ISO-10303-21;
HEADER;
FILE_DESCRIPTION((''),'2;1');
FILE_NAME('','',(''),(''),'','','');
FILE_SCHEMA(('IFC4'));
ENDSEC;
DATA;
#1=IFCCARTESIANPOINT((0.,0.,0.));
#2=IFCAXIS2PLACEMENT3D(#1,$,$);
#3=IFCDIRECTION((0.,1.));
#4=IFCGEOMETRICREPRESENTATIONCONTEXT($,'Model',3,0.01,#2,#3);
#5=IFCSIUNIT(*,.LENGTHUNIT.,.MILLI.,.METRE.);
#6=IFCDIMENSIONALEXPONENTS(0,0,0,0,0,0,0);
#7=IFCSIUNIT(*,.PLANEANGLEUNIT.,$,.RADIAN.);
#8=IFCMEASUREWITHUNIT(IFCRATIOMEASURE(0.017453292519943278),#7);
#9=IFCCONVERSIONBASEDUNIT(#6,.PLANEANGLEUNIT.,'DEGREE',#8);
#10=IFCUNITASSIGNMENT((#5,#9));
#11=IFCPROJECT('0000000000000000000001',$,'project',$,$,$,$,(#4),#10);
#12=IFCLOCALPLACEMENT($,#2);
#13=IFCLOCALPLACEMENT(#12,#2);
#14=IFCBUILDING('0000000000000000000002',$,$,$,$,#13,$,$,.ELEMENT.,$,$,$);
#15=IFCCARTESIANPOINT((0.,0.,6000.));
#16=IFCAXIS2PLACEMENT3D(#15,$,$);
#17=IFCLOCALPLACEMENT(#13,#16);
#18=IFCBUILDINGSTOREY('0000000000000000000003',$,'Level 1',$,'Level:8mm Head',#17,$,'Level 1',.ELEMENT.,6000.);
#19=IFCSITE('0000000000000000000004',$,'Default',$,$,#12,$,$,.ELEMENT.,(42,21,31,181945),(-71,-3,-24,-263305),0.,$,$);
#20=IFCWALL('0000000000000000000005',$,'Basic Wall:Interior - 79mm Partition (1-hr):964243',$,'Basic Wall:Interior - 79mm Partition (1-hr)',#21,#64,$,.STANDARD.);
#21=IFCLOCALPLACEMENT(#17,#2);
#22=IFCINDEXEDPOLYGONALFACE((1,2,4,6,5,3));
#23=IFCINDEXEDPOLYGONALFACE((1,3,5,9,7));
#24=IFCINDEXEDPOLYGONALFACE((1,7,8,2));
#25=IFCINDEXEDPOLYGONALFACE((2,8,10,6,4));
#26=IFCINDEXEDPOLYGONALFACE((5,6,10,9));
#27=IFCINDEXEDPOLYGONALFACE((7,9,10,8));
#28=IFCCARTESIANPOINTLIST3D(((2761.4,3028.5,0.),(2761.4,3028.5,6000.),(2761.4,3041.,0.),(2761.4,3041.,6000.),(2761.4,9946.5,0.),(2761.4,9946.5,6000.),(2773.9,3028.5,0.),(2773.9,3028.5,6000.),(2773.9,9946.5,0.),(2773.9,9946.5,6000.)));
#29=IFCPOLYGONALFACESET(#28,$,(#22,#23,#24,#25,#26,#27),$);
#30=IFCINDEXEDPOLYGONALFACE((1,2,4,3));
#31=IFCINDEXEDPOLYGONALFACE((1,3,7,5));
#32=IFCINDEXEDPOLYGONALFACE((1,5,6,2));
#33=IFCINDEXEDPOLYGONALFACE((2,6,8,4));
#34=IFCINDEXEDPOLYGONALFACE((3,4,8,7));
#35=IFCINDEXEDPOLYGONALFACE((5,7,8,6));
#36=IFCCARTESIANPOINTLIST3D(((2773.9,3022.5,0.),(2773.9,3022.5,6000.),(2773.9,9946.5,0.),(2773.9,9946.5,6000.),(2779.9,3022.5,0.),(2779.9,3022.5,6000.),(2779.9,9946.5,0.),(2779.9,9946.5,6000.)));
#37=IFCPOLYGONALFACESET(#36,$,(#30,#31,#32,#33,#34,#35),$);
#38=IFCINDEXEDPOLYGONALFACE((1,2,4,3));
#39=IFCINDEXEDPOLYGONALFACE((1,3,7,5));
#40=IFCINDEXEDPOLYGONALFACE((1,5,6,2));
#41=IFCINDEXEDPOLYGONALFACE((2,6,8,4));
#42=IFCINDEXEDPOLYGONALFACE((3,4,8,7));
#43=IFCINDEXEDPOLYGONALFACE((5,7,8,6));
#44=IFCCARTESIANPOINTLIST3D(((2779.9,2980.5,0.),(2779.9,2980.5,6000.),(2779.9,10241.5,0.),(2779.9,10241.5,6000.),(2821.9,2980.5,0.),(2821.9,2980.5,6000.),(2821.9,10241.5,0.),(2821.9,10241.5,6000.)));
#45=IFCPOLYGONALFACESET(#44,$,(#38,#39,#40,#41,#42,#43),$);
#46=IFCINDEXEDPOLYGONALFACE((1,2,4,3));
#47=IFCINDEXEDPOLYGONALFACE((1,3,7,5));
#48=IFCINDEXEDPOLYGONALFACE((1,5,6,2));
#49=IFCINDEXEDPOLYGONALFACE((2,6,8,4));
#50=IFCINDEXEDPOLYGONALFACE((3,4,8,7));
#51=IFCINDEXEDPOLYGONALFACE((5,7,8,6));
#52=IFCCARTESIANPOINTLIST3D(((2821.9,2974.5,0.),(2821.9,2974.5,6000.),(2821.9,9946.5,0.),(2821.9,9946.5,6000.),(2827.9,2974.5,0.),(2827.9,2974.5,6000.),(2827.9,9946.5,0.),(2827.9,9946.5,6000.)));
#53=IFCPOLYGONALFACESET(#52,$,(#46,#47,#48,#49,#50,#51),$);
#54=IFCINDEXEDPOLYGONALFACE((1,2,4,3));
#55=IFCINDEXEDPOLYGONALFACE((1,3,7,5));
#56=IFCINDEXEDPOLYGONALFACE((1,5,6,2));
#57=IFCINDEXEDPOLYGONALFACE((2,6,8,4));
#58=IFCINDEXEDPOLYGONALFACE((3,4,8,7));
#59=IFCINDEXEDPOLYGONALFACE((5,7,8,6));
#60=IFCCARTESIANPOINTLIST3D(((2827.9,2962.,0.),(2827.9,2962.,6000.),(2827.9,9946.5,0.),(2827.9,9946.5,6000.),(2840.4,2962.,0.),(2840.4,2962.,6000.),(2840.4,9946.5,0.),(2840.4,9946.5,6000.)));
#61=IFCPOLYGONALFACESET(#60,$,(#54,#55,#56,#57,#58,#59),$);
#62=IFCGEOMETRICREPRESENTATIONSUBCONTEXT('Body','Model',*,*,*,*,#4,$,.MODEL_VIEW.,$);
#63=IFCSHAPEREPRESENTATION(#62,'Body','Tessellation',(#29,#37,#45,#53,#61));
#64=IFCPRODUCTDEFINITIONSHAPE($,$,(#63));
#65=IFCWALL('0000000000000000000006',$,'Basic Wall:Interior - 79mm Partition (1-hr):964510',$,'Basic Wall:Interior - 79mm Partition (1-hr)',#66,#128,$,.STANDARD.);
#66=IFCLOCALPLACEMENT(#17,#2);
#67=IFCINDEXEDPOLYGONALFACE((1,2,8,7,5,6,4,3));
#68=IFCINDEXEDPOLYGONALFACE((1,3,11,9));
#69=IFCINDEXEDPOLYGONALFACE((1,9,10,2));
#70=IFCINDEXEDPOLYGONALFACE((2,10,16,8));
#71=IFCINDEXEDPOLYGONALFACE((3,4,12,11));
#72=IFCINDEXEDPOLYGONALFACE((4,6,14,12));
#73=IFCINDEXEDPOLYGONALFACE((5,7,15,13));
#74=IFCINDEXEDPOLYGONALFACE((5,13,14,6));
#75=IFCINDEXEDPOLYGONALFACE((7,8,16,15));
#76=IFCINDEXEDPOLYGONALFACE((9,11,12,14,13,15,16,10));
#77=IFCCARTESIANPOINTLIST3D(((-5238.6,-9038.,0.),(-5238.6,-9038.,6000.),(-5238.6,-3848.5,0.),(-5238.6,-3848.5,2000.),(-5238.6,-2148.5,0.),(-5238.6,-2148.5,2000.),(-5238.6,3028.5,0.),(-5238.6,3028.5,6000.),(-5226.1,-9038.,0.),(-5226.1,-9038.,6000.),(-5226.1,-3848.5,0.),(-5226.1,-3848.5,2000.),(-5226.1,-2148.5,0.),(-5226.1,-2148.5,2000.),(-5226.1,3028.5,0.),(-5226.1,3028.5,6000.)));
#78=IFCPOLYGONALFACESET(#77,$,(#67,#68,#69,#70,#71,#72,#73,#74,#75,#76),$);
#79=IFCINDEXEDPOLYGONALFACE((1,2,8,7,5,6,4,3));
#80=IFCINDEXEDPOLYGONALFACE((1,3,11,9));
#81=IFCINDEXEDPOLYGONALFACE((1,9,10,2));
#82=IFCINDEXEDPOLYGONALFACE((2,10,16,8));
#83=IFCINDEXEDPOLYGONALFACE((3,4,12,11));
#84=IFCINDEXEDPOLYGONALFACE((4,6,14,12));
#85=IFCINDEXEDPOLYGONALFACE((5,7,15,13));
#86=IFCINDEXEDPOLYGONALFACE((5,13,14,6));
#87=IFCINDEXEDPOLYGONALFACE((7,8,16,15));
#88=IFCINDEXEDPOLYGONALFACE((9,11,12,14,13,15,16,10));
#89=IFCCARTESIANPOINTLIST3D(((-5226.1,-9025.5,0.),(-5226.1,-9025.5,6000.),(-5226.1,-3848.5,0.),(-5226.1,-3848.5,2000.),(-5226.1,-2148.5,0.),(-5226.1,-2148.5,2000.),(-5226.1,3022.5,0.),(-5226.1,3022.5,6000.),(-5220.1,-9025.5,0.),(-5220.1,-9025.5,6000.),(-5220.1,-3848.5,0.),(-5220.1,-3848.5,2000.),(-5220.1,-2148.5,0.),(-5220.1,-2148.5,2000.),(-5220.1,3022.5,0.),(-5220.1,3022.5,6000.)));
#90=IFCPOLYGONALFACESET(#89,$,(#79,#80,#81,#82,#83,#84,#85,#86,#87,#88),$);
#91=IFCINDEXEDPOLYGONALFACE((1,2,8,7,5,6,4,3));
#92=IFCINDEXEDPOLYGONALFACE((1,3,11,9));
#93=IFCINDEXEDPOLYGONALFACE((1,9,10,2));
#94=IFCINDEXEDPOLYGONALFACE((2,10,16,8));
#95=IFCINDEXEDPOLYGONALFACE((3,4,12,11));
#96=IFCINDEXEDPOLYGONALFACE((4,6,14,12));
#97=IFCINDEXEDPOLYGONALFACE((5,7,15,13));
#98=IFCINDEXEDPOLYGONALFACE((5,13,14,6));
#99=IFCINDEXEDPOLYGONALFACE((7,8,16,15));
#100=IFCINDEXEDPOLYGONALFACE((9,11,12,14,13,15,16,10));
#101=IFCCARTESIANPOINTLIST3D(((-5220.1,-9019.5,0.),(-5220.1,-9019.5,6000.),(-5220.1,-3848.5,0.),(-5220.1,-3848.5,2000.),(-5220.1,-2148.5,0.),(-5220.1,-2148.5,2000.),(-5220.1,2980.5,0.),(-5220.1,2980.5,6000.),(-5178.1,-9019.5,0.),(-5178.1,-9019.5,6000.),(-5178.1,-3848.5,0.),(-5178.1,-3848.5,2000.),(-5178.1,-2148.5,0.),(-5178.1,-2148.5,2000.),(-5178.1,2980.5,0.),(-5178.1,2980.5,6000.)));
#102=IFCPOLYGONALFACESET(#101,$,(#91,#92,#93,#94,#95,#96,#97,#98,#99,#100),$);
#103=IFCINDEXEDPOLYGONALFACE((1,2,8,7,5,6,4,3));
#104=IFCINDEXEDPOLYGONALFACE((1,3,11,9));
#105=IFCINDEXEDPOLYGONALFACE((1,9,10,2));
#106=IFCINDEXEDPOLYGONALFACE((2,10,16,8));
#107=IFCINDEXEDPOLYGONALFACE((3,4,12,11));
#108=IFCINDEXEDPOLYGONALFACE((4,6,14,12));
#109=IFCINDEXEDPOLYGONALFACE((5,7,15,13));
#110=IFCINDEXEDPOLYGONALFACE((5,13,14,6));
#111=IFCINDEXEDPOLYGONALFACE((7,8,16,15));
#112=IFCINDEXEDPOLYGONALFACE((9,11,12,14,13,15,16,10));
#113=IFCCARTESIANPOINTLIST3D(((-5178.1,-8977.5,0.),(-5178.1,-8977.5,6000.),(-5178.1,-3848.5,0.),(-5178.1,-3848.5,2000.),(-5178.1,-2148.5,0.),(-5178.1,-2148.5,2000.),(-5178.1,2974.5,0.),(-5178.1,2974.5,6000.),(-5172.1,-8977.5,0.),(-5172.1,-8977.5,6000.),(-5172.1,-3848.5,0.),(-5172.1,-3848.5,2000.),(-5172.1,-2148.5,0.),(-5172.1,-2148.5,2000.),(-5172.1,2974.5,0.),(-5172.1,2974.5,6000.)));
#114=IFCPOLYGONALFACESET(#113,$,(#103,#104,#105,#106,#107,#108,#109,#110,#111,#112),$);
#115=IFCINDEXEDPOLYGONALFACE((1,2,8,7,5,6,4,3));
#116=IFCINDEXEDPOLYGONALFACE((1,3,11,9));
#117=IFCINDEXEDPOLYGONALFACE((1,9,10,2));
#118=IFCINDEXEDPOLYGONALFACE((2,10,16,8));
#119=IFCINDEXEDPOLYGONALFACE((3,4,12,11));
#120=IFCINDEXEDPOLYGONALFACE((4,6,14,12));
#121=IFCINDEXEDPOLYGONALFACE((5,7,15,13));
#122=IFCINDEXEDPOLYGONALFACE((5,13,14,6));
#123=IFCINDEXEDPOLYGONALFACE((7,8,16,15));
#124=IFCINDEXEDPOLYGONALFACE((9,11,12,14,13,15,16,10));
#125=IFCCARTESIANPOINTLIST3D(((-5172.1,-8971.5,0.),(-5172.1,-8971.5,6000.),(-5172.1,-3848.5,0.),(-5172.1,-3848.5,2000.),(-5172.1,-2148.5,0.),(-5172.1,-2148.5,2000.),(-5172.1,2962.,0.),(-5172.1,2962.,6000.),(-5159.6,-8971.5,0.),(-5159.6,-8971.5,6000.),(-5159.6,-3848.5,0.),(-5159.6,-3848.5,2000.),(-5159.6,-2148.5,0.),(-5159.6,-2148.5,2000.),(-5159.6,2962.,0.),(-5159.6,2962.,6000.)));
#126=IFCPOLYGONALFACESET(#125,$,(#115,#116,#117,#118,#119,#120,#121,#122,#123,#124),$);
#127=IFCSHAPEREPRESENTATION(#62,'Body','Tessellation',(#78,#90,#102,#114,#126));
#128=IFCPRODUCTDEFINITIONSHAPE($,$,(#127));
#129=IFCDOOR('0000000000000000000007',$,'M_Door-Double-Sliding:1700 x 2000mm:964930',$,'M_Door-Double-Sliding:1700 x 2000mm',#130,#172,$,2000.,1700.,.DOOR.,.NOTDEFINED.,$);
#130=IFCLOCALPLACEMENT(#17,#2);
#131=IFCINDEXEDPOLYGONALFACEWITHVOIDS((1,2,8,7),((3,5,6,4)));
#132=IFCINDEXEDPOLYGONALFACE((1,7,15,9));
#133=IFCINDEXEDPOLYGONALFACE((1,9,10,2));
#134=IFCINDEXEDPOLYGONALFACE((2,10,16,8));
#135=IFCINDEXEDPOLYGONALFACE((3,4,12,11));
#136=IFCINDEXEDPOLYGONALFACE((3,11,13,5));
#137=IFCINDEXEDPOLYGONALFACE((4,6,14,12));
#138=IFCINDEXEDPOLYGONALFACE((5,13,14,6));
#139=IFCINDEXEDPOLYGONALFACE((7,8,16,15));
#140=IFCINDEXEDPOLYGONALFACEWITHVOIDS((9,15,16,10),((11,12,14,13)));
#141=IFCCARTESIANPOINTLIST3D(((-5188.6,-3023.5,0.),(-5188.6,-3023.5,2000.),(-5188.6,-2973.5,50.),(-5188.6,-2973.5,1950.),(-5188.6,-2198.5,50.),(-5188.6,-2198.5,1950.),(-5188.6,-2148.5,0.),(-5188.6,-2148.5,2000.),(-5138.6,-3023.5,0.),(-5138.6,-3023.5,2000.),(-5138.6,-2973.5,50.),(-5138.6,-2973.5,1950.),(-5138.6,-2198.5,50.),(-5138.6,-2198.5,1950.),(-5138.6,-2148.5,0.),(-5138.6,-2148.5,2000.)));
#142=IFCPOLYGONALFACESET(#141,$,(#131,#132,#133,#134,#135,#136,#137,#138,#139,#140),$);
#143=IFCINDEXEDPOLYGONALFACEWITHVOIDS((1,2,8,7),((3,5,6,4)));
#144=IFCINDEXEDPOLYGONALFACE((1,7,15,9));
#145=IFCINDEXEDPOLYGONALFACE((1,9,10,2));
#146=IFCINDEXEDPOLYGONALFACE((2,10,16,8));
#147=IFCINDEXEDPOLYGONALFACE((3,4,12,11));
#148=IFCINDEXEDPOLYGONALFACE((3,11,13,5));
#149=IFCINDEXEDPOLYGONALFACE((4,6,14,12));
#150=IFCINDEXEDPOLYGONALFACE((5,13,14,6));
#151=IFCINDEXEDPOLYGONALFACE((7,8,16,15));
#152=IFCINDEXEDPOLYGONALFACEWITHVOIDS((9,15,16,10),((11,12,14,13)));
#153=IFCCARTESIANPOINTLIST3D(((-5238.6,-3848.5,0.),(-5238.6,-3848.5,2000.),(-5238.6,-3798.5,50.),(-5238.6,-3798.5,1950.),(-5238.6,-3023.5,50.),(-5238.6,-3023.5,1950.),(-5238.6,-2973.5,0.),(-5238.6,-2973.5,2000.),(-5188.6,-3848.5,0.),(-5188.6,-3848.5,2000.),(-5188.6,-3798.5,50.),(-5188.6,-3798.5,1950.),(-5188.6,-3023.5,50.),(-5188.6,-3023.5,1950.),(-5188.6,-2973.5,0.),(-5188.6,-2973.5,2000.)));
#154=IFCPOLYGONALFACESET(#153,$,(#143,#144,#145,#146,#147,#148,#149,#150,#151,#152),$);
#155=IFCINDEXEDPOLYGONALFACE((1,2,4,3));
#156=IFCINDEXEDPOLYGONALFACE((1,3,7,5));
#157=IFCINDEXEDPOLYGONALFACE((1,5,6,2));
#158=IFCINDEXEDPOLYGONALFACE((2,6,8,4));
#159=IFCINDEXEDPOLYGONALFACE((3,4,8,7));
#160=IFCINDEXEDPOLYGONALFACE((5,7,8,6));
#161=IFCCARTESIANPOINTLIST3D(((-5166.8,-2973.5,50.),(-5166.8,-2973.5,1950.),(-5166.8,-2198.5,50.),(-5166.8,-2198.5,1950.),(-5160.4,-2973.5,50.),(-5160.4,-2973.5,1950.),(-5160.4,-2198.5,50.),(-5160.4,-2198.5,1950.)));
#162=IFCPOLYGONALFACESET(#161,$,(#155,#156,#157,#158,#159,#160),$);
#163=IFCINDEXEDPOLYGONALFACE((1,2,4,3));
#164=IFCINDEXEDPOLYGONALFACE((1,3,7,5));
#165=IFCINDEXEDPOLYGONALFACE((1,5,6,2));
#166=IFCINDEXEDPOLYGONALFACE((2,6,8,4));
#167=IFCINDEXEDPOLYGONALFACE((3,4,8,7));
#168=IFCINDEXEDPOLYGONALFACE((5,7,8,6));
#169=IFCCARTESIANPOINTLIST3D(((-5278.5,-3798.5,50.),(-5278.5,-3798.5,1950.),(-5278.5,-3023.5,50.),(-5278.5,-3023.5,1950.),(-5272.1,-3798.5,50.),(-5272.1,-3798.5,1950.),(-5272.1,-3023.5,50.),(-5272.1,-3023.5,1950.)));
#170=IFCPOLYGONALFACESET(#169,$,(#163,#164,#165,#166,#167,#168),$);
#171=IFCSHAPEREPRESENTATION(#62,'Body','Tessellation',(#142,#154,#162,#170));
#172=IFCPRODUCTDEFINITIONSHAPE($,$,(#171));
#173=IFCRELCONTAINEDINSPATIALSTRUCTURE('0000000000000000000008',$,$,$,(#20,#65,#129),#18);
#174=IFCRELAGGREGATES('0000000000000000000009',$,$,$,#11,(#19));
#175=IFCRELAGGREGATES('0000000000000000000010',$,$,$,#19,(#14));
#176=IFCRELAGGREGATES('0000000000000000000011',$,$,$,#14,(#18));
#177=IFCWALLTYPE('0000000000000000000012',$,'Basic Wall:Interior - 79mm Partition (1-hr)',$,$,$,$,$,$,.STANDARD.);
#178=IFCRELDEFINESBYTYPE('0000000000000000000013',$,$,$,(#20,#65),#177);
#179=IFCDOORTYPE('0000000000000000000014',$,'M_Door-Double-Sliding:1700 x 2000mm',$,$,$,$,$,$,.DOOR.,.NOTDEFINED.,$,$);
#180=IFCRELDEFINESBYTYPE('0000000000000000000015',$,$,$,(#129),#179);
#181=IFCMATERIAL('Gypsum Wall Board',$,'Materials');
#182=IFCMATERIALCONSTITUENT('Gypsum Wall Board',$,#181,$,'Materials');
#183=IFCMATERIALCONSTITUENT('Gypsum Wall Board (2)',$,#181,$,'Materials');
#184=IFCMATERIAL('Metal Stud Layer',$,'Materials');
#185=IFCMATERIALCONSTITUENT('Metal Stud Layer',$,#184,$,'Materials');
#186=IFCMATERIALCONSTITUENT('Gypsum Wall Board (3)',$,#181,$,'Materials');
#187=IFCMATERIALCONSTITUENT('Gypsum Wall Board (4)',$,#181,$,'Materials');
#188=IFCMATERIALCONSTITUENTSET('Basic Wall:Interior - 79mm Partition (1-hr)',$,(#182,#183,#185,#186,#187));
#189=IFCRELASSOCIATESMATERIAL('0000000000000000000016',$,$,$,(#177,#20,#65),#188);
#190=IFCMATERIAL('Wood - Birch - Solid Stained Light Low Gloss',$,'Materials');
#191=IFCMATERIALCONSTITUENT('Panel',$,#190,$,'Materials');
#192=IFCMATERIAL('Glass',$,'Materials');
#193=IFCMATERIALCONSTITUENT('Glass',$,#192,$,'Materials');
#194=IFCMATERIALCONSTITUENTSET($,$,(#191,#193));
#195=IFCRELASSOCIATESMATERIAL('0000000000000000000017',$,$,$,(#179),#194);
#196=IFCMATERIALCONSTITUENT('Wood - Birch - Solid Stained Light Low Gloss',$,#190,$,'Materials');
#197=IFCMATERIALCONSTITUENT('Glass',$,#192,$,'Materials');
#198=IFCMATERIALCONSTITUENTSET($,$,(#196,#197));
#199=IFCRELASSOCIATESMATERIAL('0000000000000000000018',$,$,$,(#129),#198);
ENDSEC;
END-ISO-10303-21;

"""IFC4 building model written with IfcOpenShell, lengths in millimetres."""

from ifc_helpers import new_model, entity, si_unit, converted_unit, direction, frame, origin, place, context, subcontext, project, spatial, indexed_curve, outline, extrude, source, transform, mapped, material, constituent, constituent_set, type_object, type_shapes, element, fill, save


model = new_model("IFC4")

# Units and contexts
model_context = context("Model", 3, precision=0.01, world=origin(), true_north=direction((0.0, 1.0)))
body_context = subcontext(model_context, "Body", "Model", "MODEL_VIEW")
ifc_project = project(units=[si_unit("LENGTHUNIT", "METRE", prefix="MILLI"), converted_unit("PLANEANGLEUNIT", "DEGREE", entity("IfcRatioMeasure", 0.017453292519943278), si_unit("PLANEANGLEUNIT", "RADIAN"), dimensions=[0, 0, 0, 0, 0, 0, 0])], contexts=[model_context])

# Site, building, storey
site_placement = place(None, origin())
site = spatial("IfcSite", under=ifc_project, at=site_placement, Name="Default", CompositionType="ELEMENT", RefLatitude=(42, 21, 31, 181945), RefLongitude=(-71, -3, -24, -263305), RefElevation=0.0)
building_placement = place(site_placement, origin())
building = spatial("IfcBuilding", under=site, at=building_placement, CompositionType="ELEMENT")
storey_placement = place(building_placement, frame((0.0, 0.0, 6000.0)))
storey = spatial("IfcBuildingStorey", under=building, at=storey_placement, Name="Level 1", ObjectType="Level:8mm Head", LongName="Level 1", CompositionType="ELEMENT", Elevation=6000.0)

# Wall
ifc_material_1 = material(Name="Gypsum Wall Board", Category="Materials")
ifc_constituent_1 = constituent(ifc_material_1, Name="Gypsum Wall Board", Category="Materials")
ifc_constituent_2 = constituent(ifc_material_1, Name="Gypsum Wall Board (2)", Category="Materials")
ifc_material_2 = material(Name="Metal Stud Layer", Category="Materials")
ifc_constituent_3 = constituent(ifc_material_2, Name="Metal Stud Layer", Category="Materials")
ifc_constituent_4 = constituent(ifc_material_1, Name="Gypsum Wall Board (3)", Category="Materials")
ifc_constituent_5 = constituent(ifc_material_1, Name="Gypsum Wall Board (4)", Category="Materials")
ifc_constituent_set_1 = constituent_set(constituents=[ifc_constituent_1, ifc_constituent_2, ifc_constituent_3, ifc_constituent_4, ifc_constituent_5], Name="Basic Wall:Interior - 79mm Partition (1-hr)")
wall_type = type_object("IfcWallType", Name="Basic Wall:Interior - 79mm Partition (1-hr)", PredefinedType="STANDARD", material=ifc_constituent_set_1)
wall_1_placement = place(storey_placement, frame((2800.9, 9946.5, 0.0), z_axis=(0.0, 0.0, 1.0), x_axis=(0.0, -1.0, 0.0)))
element("IfcWall", 1, at=wall_1_placement, inside=storey, type_object=wall_type, material=ifc_constituent_set_1, Name="Basic Wall:Interior - 79mm Partition (1-hr):964243", ObjectType="Basic Wall:Interior - 79mm Partition (1-hr)", PredefinedType="STANDARD", context=body_context, shape_type="SweptSolid", body=[
    extrude(outline(indexed_curve([(2757.2, -5.0), (2769.7, -5.0), (2769.7, 7.5), (-4148.3, 7.5), (-4148.3, -5.0), (2757.2, -5.0)], self_intersect=False)), frame((4148.3, -34.5, 0.0)), (0.0, 0.0, 1.0), 6000.0),
    extrude(outline(indexed_curve([(-3462.0, -3.0), (3462.0, -3.0), (3462.0, 3.0), (-3462.0, 3.0), (-3462.0, -3.0)], self_intersect=False)), frame((3462.0, -24.0, 0.0)), (0.0, 0.0, 1.0), 6000.0),
    extrude(outline(indexed_curve([(-3630.5, -21.0), (3630.5, -21.0), (3630.5, 21.0), (-3630.5, 21.0), (-3630.5, -21.0)], self_intersect=False)), frame((3335.5, 0.0, 0.0)), (0.0, 0.0, 1.0), 6000.0),
    extrude(outline(indexed_curve([(-3486.0, -3.0), (3486.0, -3.0), (3486.0, 3.0), (-3486.0, 3.0), (-3486.0, -3.0)], self_intersect=False)), frame((3486.0, 24.0, 0.0)), (0.0, 0.0, 1.0), 6000.0),
    extrude(outline(indexed_curve([(-6.3, -3492.3), (6.2, -3492.3), (6.3, 3492.3), (-6.2, 3492.3), (-6.3, -3492.3)], self_intersect=False)), frame((3492.3, 33.3, 0.0), z_axis=(0.0, 0.0, 1.0), x_axis=(0.0, -1.0, 0.0)), (0.0, 0.0, 1.0), 6000.0),
])

# Wall, opening, door
ifc_material_3 = material(Name="Wood - Birch - Solid Stained Light Low Gloss", Category="Materials")
ifc_material_4 = material(Name="Glass", Category="Materials")
ifc_constituent_6 = constituent(ifc_material_3, Name="Panel", Category="Materials")
ifc_constituent_7 = constituent(ifc_material_4, Name="Glass", Category="Materials")
ifc_constituent_set_2 = constituent_set(constituents=[ifc_constituent_6, ifc_constituent_7])
door_type = type_object("IfcDoorType", Name="M_Door-Double-Sliding:1700 x 2000mm", OperationType="NOTDEFINED", PredefinedType="DOOR", material=ifc_constituent_set_2)
shared_shape_1 = source(origin(), body_context, "Body", "SweptSolid", [
    extrude(outline(indexed_curve([(-437.5, -1000.0), (437.5, -1000.0), (437.5, 1000.0), (-437.5, 1000.0), (-437.5, -1000.0)], self_intersect=False), holes=[indexed_curve([(-387.5, -950.0), (-387.5, 950.0), (387.5, 950.0), (387.5, -950.0), (-387.5, -950.0)], self_intersect=False)]), frame((1262.5, -21.0, 1000.0), z_axis=(0.0, 1.0, 0.0), x_axis=(1.0, 0.0, 0.0)), (0.0, 0.0, 1.0), 50.0),
    extrude(outline(indexed_curve([(-1000.0, -437.5), (1000.0, -437.5), (1000.0, 437.5), (-1000.0, 437.5), (-1000.0, -437.5)], self_intersect=False), holes=[indexed_curve([(-950.0, -387.5), (-950.0, 387.5), (950.0, 387.5), (950.0, -387.5), (-950.0, -387.5)], self_intersect=False)]), frame((437.5, 29.0, 1000.0), z_axis=(0.0, 1.0, 0.0), x_axis=(0.0, 0.0, -1.0)), (0.0, 0.0, 1.0), 50.0),
    extrude(outline(indexed_curve([(-3.2, -387.5), (3.2, -387.5), (3.2, 387.5), (-3.2, 387.5), (-3.2, -387.5)], self_intersect=False)), frame((1262.5, 4.0, 50.0), z_axis=(0.0, 0.0, 1.0), x_axis=(0.0, -1.0, 0.0)), (0.0, 0.0, 1.0), 1900.0),
    extrude(outline(indexed_curve([(-3.2, -387.5), (3.2, -387.5), (3.2, 387.5), (-3.2, 387.5), (-3.2, -387.5)], self_intersect=False)), frame((437.5, 115.7, 50.0), z_axis=(0.0, 0.0, 1.0), x_axis=(0.0, 1.0, 0.0)), (0.0, 0.0, 1.0), 1900.0),
])
type_shapes(door_type, [shared_shape_1])
wall_2_placement = place(storey_placement, frame((-5199.1, 2962.0, 0.0), z_axis=(0.0, 0.0, 1.0), x_axis=(0.0, -1.0, 0.0)))
wall_2 = element("IfcWall", 2, at=wall_2_placement, inside=storey, type_object=wall_type, material=ifc_constituent_set_1, Name="Basic Wall:Interior - 79mm Partition (1-hr):964510", ObjectType="Basic Wall:Interior - 79mm Partition (1-hr)", PredefinedType="STANDARD", context=body_context, shape_type="SweptSolid", body=[
    extrude(outline(indexed_curve([(-2000.0, -6030.1), (4000.0, -6030.1), (4000.0, 6036.4), (-2000.0, 6036.4), (-2000.0, 846.9), (0.0, 846.9), (0.0, -853.1), (-2000.0, -853.1), (-2000.0, -6030.1)], self_intersect=False)), frame((5963.6, -39.5, 2000.0), z_axis=(0.0, 1.0, 0.0), x_axis=(0.0, 0.0, 1.0)), (0.0, 0.0, 1.0), 12.5),
    extrude(outline(indexed_curve([(-2000.0, -6022.5), (4000.0, -6022.5), (4000.0, 6025.5), (-2000.0, 6025.5), (-2000.0, 848.5), (0.0, 848.5), (0.0, -851.5), (-2000.0, -851.5), (-2000.0, -6022.5)], self_intersect=False)), frame((5962.0, -27.0, 2000.0), z_axis=(0.0, 1.0, 0.0), x_axis=(0.0, 0.0, 1.0)), (0.0, 0.0, 1.0), 6.0),
    extrude(outline(indexed_curve([(-2000.0, -5989.5), (4000.0, -5989.5), (4000.0, 6010.5), (-2000.0, 6010.5), (-2000.0, 839.5), (0.0, 839.5), (0.0, -860.5), (-2000.0, -860.5), (-2000.0, -5989.5)], self_intersect=False)), frame((5971.0, -21.0, 2000.0), z_axis=(0.0, 1.0, 0.0), x_axis=(0.0, 0.0, 1.0)), (0.0, 0.0, 1.0), 42.0),
    extrude(outline(indexed_curve([(-2000.0, -5974.5), (4000.0, -5974.5), (4000.0, 5977.5), (-2000.0, 5977.5), (-2000.0, 848.5), (0.0, 848.5), (0.0, -851.5), (-2000.0, -851.5), (-2000.0, -5974.5)], self_intersect=False)), frame((5962.0, 21.0, 2000.0), z_axis=(0.0, 1.0, 0.0), x_axis=(0.0, 0.0, 1.0)), (0.0, 0.0, 1.0), 6.0),
    extrude(outline(indexed_curve([(-2000.0, -5963.6), (4000.0, -5963.6), (4000.0, 5969.9), (-2000.0, 5969.9), (-2000.0, 846.9), (0.0, 846.9), (0.0, -853.1), (-2000.0, -853.1), (-2000.0, -5963.6)], self_intersect=False)), frame((5963.6, 27.0, 2000.0), z_axis=(0.0, 1.0, 0.0), x_axis=(0.0, 0.0, 1.0)), (0.0, 0.0, 1.0), 12.5),
])
opening_1_placement = place(wall_2_placement, frame((6810.5, 39.5, 0.0)))
opening_1 = element("IfcOpeningElement", 3, at=opening_1_placement, cuts=wall_2, PredefinedType="OPENING", context=body_context, shape_type="SweptSolid", body=[
    extrude(outline(indexed_curve([(2000.0, 0.0), (2000.0, 1700.0), (0.0, 1700.0), (0.0, 0.0), (2000.0, 0.0)], self_intersect=False)), frame((0.0, 0.0, 0.0), z_axis=(0.0, -1.0, 0.0), x_axis=(0.0, 0.0, 1.0)), (0.0, 0.0, 1.0), 79.0),
])
ifc_constituent_8 = constituent(ifc_material_3, Name="Wood - Birch - Solid Stained Light Low Gloss", Category="Materials")
ifc_constituent_9 = constituent(ifc_material_4, Name="Glass", Category="Materials")
ifc_constituent_set_3 = constituent_set(constituents=[ifc_constituent_8, ifc_constituent_9])
door_1_placement = place(opening_1_placement, frame((0.0, 0.0, 0.0), z_axis=(0.0, 0.0, 1.0), x_axis=(-1.0, 0.0, 0.0)))
door_1 = element("IfcDoor", 4, at=door_1_placement, inside=storey, type_object=door_type, material=ifc_constituent_set_3, Name="M_Door-Double-Sliding:1700 x 2000mm:964930", ObjectType="M_Door-Double-Sliding:1700 x 2000mm", OperationType="NOTDEFINED", OverallHeight=2000.0, OverallWidth=1700.0, PredefinedType="DOOR", context=body_context, shape_type="MappedRepresentation", body=[
    mapped(shared_shape_1, transform((0.0, 0.0, 0.0), scale=1.0)),
])
fill(opening_1, door_1)

save(model, "model.ifc")
